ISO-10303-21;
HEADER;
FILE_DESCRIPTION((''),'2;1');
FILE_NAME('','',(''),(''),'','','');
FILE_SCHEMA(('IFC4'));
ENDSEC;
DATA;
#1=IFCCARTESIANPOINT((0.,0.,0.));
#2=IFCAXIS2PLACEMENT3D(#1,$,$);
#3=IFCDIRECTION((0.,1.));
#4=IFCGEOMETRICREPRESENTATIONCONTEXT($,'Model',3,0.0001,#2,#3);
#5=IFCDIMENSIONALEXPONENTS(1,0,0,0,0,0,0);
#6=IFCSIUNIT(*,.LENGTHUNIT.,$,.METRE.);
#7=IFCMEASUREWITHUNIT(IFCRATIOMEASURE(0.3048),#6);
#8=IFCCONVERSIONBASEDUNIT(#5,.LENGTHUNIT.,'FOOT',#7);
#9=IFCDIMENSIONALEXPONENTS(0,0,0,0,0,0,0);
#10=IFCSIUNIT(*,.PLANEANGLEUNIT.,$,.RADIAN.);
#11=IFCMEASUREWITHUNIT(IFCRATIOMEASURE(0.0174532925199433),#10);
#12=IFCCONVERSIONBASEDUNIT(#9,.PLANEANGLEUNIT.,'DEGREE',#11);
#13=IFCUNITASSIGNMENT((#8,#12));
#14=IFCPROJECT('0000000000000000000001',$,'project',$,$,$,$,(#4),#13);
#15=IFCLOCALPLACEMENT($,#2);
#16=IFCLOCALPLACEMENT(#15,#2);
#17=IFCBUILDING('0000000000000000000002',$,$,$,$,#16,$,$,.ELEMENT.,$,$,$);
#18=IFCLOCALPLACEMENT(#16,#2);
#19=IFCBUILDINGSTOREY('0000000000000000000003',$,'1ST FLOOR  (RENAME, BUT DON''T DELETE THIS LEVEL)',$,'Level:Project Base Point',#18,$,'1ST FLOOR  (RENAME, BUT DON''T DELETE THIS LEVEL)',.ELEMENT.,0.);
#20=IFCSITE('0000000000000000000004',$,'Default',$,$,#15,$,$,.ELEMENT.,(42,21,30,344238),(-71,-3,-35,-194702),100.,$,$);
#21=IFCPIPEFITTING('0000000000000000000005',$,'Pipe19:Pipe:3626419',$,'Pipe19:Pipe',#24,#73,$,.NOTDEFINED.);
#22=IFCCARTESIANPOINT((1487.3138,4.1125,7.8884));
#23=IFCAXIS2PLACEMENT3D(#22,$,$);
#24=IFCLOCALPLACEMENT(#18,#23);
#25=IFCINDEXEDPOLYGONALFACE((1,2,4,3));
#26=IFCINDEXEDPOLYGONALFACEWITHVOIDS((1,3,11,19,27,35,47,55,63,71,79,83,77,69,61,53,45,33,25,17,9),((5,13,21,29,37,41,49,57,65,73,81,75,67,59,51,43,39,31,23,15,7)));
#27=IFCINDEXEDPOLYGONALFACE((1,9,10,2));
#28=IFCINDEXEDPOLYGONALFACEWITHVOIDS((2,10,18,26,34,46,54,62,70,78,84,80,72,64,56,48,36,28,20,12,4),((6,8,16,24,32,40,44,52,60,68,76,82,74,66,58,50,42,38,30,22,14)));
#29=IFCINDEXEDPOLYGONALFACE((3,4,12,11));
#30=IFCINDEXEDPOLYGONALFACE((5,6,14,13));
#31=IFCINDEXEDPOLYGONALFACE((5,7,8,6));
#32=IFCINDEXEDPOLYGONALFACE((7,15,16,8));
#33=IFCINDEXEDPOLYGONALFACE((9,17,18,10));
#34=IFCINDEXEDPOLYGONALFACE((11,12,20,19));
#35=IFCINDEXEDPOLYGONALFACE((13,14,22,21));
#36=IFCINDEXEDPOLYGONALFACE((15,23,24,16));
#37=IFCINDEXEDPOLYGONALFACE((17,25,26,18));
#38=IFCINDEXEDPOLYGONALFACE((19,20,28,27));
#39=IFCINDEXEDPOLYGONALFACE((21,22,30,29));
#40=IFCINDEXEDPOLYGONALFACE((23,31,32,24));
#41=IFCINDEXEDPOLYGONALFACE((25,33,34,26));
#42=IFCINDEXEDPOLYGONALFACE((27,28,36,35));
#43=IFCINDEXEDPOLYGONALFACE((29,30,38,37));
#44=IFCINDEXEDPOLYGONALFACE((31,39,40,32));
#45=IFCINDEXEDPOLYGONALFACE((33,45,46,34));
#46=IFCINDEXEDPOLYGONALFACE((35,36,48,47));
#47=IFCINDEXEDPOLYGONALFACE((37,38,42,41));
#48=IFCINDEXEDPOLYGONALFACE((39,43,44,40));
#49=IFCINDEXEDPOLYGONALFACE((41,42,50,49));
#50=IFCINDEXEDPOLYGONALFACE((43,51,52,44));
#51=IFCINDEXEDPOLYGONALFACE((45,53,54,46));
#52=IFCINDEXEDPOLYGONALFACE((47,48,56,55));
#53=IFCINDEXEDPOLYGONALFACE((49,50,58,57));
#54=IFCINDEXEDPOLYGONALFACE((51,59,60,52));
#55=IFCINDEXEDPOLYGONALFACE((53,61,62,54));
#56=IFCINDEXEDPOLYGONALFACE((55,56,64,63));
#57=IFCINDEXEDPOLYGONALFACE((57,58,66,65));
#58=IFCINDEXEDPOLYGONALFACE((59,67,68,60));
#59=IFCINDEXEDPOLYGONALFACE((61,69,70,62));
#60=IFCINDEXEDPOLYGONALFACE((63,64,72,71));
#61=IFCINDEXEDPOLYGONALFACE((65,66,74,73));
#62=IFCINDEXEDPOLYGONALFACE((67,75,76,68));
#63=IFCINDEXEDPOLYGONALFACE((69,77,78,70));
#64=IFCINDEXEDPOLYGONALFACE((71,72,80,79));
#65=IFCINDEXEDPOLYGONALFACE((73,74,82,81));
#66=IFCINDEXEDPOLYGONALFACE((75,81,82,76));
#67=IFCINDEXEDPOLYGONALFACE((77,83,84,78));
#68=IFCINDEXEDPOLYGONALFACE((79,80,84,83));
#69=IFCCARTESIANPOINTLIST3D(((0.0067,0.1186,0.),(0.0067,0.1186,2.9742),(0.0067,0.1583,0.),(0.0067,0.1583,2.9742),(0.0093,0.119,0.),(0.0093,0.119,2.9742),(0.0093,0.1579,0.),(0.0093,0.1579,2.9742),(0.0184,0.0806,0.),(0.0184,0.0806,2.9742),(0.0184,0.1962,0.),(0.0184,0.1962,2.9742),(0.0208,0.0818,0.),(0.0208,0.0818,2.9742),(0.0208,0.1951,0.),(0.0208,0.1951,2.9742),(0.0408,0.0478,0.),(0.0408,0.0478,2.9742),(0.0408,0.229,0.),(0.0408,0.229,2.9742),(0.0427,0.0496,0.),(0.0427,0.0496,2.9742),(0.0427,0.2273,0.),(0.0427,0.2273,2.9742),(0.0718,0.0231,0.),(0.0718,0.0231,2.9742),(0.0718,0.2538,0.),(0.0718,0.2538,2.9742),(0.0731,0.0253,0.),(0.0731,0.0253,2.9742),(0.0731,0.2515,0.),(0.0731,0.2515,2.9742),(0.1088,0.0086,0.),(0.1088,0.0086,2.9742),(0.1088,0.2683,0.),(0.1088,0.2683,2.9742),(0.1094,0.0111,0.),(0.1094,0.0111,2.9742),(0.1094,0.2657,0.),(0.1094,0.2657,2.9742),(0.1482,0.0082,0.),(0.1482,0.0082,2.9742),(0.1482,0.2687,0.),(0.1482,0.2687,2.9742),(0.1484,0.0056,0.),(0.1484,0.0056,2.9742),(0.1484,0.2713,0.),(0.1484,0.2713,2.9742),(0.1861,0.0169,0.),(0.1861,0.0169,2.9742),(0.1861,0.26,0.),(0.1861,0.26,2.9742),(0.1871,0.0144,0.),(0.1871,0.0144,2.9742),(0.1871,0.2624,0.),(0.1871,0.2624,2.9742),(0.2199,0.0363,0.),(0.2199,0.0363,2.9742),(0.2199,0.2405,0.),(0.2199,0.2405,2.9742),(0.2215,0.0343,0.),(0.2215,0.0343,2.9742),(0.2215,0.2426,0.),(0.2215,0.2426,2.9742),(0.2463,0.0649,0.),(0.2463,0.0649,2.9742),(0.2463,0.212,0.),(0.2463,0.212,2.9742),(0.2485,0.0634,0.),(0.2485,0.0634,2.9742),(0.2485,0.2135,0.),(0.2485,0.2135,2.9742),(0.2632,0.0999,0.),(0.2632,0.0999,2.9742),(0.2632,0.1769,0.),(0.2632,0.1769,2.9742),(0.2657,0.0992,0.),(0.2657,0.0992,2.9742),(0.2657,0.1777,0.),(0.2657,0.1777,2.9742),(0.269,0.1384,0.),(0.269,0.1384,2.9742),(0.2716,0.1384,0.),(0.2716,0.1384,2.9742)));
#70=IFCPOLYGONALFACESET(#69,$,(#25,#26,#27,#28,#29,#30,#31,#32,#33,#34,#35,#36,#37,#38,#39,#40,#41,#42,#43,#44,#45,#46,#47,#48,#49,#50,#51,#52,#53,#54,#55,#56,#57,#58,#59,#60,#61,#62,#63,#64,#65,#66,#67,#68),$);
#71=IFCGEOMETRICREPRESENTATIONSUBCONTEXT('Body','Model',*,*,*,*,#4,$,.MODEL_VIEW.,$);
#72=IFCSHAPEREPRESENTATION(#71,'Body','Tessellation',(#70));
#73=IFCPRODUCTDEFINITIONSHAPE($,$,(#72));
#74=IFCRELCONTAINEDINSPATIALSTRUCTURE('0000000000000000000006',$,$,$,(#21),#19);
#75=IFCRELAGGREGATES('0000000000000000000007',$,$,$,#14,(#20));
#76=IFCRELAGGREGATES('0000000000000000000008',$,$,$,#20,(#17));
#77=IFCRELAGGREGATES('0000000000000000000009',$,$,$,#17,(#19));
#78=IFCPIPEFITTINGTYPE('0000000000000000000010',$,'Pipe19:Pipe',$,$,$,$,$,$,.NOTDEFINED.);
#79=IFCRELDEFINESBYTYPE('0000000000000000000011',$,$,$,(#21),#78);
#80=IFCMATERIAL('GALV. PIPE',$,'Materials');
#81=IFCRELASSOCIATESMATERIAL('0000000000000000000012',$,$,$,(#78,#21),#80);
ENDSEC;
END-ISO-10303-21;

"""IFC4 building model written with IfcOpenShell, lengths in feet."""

from ifc_helpers import new_model, entity, si_unit, converted_unit, direction, frame, frame_2d, origin, place, context, subcontext, project, spatial, hollow_circle, extrude, source, transform, mapped, material, type_object, type_shapes, element, save


model = new_model("IFC4")

# Units and contexts
model_context = context("Model", 3, precision=0.0001, world=origin(), true_north=direction((0.0, 1.0)))
body_context = subcontext(model_context, "Body", "Model", "MODEL_VIEW")
ifc_project = project(units=[converted_unit("LENGTHUNIT", "FOOT", entity("IfcRatioMeasure", 0.3048), si_unit("LENGTHUNIT", "METRE"), dimensions=[1, 0, 0, 0, 0, 0, 0]), converted_unit("PLANEANGLEUNIT", "DEGREE", entity("IfcRatioMeasure", 0.0174532925199433), si_unit("PLANEANGLEUNIT", "RADIAN"), dimensions=[0, 0, 0, 0, 0, 0, 0])], contexts=[model_context])

# Site, building, storey
site_placement = place(None, origin())
site = spatial("IfcSite", under=ifc_project, at=site_placement, Name="Default", CompositionType="ELEMENT", RefLatitude=(42, 21, 30, 344238), RefLongitude=(-71, -3, -35, -194702), RefElevation=100.0)
building_placement = place(site_placement, origin())
building = spatial("IfcBuilding", under=site, at=building_placement, CompositionType="ELEMENT")
storey_placement = place(building_placement, origin())
storey = spatial("IfcBuildingStorey", under=building, at=storey_placement, Name="1ST FLOOR  (RENAME, BUT DON'T DELETE THIS LEVEL)", ObjectType="Level:Project Base Point", LongName="1ST FLOOR  (RENAME, BUT DON'T DELETE THIS LEVEL)", CompositionType="ELEMENT", Elevation=0.0)

# Pipe fitting
ifc_material_1 = material(Name="GALV. PIPE", Category="Materials")
pipe_fitting_type_1 = type_object("IfcPipeFittingType", Name="Pipe19:Pipe", PredefinedType="NOTDEFINED", material=ifc_material_1)
shared_shape_1 = source(origin(), body_context, "Body", "SweptSolid", [
    extrude(hollow_circle(Radius=0.1332, WallThickness=0.0026, at=frame_2d((0.0, 0.0), x_axis=(1.0, 0.0))), frame((0.1384, 0.1384, 0.0)), (0.0, 0.0, 1.0), 2.9742),
])
type_shapes(pipe_fitting_type_1, [shared_shape_1])
pipe_fitting_1_placement = place(storey_placement, frame((1487.3138, 4.1125, 7.8884)))
element("IfcPipeFitting", 1, at=pipe_fitting_1_placement, inside=storey, type_object=pipe_fitting_type_1, material=ifc_material_1, Name="Pipe19:Pipe:3626419", ObjectType="Pipe19:Pipe", PredefinedType="NOTDEFINED", context=body_context, shape_type="MappedRepresentation", body=[
    mapped(shared_shape_1, transform((0.0, 0.0, 0.0), scale=1.0)),
])

save(model, "model.ifc")
